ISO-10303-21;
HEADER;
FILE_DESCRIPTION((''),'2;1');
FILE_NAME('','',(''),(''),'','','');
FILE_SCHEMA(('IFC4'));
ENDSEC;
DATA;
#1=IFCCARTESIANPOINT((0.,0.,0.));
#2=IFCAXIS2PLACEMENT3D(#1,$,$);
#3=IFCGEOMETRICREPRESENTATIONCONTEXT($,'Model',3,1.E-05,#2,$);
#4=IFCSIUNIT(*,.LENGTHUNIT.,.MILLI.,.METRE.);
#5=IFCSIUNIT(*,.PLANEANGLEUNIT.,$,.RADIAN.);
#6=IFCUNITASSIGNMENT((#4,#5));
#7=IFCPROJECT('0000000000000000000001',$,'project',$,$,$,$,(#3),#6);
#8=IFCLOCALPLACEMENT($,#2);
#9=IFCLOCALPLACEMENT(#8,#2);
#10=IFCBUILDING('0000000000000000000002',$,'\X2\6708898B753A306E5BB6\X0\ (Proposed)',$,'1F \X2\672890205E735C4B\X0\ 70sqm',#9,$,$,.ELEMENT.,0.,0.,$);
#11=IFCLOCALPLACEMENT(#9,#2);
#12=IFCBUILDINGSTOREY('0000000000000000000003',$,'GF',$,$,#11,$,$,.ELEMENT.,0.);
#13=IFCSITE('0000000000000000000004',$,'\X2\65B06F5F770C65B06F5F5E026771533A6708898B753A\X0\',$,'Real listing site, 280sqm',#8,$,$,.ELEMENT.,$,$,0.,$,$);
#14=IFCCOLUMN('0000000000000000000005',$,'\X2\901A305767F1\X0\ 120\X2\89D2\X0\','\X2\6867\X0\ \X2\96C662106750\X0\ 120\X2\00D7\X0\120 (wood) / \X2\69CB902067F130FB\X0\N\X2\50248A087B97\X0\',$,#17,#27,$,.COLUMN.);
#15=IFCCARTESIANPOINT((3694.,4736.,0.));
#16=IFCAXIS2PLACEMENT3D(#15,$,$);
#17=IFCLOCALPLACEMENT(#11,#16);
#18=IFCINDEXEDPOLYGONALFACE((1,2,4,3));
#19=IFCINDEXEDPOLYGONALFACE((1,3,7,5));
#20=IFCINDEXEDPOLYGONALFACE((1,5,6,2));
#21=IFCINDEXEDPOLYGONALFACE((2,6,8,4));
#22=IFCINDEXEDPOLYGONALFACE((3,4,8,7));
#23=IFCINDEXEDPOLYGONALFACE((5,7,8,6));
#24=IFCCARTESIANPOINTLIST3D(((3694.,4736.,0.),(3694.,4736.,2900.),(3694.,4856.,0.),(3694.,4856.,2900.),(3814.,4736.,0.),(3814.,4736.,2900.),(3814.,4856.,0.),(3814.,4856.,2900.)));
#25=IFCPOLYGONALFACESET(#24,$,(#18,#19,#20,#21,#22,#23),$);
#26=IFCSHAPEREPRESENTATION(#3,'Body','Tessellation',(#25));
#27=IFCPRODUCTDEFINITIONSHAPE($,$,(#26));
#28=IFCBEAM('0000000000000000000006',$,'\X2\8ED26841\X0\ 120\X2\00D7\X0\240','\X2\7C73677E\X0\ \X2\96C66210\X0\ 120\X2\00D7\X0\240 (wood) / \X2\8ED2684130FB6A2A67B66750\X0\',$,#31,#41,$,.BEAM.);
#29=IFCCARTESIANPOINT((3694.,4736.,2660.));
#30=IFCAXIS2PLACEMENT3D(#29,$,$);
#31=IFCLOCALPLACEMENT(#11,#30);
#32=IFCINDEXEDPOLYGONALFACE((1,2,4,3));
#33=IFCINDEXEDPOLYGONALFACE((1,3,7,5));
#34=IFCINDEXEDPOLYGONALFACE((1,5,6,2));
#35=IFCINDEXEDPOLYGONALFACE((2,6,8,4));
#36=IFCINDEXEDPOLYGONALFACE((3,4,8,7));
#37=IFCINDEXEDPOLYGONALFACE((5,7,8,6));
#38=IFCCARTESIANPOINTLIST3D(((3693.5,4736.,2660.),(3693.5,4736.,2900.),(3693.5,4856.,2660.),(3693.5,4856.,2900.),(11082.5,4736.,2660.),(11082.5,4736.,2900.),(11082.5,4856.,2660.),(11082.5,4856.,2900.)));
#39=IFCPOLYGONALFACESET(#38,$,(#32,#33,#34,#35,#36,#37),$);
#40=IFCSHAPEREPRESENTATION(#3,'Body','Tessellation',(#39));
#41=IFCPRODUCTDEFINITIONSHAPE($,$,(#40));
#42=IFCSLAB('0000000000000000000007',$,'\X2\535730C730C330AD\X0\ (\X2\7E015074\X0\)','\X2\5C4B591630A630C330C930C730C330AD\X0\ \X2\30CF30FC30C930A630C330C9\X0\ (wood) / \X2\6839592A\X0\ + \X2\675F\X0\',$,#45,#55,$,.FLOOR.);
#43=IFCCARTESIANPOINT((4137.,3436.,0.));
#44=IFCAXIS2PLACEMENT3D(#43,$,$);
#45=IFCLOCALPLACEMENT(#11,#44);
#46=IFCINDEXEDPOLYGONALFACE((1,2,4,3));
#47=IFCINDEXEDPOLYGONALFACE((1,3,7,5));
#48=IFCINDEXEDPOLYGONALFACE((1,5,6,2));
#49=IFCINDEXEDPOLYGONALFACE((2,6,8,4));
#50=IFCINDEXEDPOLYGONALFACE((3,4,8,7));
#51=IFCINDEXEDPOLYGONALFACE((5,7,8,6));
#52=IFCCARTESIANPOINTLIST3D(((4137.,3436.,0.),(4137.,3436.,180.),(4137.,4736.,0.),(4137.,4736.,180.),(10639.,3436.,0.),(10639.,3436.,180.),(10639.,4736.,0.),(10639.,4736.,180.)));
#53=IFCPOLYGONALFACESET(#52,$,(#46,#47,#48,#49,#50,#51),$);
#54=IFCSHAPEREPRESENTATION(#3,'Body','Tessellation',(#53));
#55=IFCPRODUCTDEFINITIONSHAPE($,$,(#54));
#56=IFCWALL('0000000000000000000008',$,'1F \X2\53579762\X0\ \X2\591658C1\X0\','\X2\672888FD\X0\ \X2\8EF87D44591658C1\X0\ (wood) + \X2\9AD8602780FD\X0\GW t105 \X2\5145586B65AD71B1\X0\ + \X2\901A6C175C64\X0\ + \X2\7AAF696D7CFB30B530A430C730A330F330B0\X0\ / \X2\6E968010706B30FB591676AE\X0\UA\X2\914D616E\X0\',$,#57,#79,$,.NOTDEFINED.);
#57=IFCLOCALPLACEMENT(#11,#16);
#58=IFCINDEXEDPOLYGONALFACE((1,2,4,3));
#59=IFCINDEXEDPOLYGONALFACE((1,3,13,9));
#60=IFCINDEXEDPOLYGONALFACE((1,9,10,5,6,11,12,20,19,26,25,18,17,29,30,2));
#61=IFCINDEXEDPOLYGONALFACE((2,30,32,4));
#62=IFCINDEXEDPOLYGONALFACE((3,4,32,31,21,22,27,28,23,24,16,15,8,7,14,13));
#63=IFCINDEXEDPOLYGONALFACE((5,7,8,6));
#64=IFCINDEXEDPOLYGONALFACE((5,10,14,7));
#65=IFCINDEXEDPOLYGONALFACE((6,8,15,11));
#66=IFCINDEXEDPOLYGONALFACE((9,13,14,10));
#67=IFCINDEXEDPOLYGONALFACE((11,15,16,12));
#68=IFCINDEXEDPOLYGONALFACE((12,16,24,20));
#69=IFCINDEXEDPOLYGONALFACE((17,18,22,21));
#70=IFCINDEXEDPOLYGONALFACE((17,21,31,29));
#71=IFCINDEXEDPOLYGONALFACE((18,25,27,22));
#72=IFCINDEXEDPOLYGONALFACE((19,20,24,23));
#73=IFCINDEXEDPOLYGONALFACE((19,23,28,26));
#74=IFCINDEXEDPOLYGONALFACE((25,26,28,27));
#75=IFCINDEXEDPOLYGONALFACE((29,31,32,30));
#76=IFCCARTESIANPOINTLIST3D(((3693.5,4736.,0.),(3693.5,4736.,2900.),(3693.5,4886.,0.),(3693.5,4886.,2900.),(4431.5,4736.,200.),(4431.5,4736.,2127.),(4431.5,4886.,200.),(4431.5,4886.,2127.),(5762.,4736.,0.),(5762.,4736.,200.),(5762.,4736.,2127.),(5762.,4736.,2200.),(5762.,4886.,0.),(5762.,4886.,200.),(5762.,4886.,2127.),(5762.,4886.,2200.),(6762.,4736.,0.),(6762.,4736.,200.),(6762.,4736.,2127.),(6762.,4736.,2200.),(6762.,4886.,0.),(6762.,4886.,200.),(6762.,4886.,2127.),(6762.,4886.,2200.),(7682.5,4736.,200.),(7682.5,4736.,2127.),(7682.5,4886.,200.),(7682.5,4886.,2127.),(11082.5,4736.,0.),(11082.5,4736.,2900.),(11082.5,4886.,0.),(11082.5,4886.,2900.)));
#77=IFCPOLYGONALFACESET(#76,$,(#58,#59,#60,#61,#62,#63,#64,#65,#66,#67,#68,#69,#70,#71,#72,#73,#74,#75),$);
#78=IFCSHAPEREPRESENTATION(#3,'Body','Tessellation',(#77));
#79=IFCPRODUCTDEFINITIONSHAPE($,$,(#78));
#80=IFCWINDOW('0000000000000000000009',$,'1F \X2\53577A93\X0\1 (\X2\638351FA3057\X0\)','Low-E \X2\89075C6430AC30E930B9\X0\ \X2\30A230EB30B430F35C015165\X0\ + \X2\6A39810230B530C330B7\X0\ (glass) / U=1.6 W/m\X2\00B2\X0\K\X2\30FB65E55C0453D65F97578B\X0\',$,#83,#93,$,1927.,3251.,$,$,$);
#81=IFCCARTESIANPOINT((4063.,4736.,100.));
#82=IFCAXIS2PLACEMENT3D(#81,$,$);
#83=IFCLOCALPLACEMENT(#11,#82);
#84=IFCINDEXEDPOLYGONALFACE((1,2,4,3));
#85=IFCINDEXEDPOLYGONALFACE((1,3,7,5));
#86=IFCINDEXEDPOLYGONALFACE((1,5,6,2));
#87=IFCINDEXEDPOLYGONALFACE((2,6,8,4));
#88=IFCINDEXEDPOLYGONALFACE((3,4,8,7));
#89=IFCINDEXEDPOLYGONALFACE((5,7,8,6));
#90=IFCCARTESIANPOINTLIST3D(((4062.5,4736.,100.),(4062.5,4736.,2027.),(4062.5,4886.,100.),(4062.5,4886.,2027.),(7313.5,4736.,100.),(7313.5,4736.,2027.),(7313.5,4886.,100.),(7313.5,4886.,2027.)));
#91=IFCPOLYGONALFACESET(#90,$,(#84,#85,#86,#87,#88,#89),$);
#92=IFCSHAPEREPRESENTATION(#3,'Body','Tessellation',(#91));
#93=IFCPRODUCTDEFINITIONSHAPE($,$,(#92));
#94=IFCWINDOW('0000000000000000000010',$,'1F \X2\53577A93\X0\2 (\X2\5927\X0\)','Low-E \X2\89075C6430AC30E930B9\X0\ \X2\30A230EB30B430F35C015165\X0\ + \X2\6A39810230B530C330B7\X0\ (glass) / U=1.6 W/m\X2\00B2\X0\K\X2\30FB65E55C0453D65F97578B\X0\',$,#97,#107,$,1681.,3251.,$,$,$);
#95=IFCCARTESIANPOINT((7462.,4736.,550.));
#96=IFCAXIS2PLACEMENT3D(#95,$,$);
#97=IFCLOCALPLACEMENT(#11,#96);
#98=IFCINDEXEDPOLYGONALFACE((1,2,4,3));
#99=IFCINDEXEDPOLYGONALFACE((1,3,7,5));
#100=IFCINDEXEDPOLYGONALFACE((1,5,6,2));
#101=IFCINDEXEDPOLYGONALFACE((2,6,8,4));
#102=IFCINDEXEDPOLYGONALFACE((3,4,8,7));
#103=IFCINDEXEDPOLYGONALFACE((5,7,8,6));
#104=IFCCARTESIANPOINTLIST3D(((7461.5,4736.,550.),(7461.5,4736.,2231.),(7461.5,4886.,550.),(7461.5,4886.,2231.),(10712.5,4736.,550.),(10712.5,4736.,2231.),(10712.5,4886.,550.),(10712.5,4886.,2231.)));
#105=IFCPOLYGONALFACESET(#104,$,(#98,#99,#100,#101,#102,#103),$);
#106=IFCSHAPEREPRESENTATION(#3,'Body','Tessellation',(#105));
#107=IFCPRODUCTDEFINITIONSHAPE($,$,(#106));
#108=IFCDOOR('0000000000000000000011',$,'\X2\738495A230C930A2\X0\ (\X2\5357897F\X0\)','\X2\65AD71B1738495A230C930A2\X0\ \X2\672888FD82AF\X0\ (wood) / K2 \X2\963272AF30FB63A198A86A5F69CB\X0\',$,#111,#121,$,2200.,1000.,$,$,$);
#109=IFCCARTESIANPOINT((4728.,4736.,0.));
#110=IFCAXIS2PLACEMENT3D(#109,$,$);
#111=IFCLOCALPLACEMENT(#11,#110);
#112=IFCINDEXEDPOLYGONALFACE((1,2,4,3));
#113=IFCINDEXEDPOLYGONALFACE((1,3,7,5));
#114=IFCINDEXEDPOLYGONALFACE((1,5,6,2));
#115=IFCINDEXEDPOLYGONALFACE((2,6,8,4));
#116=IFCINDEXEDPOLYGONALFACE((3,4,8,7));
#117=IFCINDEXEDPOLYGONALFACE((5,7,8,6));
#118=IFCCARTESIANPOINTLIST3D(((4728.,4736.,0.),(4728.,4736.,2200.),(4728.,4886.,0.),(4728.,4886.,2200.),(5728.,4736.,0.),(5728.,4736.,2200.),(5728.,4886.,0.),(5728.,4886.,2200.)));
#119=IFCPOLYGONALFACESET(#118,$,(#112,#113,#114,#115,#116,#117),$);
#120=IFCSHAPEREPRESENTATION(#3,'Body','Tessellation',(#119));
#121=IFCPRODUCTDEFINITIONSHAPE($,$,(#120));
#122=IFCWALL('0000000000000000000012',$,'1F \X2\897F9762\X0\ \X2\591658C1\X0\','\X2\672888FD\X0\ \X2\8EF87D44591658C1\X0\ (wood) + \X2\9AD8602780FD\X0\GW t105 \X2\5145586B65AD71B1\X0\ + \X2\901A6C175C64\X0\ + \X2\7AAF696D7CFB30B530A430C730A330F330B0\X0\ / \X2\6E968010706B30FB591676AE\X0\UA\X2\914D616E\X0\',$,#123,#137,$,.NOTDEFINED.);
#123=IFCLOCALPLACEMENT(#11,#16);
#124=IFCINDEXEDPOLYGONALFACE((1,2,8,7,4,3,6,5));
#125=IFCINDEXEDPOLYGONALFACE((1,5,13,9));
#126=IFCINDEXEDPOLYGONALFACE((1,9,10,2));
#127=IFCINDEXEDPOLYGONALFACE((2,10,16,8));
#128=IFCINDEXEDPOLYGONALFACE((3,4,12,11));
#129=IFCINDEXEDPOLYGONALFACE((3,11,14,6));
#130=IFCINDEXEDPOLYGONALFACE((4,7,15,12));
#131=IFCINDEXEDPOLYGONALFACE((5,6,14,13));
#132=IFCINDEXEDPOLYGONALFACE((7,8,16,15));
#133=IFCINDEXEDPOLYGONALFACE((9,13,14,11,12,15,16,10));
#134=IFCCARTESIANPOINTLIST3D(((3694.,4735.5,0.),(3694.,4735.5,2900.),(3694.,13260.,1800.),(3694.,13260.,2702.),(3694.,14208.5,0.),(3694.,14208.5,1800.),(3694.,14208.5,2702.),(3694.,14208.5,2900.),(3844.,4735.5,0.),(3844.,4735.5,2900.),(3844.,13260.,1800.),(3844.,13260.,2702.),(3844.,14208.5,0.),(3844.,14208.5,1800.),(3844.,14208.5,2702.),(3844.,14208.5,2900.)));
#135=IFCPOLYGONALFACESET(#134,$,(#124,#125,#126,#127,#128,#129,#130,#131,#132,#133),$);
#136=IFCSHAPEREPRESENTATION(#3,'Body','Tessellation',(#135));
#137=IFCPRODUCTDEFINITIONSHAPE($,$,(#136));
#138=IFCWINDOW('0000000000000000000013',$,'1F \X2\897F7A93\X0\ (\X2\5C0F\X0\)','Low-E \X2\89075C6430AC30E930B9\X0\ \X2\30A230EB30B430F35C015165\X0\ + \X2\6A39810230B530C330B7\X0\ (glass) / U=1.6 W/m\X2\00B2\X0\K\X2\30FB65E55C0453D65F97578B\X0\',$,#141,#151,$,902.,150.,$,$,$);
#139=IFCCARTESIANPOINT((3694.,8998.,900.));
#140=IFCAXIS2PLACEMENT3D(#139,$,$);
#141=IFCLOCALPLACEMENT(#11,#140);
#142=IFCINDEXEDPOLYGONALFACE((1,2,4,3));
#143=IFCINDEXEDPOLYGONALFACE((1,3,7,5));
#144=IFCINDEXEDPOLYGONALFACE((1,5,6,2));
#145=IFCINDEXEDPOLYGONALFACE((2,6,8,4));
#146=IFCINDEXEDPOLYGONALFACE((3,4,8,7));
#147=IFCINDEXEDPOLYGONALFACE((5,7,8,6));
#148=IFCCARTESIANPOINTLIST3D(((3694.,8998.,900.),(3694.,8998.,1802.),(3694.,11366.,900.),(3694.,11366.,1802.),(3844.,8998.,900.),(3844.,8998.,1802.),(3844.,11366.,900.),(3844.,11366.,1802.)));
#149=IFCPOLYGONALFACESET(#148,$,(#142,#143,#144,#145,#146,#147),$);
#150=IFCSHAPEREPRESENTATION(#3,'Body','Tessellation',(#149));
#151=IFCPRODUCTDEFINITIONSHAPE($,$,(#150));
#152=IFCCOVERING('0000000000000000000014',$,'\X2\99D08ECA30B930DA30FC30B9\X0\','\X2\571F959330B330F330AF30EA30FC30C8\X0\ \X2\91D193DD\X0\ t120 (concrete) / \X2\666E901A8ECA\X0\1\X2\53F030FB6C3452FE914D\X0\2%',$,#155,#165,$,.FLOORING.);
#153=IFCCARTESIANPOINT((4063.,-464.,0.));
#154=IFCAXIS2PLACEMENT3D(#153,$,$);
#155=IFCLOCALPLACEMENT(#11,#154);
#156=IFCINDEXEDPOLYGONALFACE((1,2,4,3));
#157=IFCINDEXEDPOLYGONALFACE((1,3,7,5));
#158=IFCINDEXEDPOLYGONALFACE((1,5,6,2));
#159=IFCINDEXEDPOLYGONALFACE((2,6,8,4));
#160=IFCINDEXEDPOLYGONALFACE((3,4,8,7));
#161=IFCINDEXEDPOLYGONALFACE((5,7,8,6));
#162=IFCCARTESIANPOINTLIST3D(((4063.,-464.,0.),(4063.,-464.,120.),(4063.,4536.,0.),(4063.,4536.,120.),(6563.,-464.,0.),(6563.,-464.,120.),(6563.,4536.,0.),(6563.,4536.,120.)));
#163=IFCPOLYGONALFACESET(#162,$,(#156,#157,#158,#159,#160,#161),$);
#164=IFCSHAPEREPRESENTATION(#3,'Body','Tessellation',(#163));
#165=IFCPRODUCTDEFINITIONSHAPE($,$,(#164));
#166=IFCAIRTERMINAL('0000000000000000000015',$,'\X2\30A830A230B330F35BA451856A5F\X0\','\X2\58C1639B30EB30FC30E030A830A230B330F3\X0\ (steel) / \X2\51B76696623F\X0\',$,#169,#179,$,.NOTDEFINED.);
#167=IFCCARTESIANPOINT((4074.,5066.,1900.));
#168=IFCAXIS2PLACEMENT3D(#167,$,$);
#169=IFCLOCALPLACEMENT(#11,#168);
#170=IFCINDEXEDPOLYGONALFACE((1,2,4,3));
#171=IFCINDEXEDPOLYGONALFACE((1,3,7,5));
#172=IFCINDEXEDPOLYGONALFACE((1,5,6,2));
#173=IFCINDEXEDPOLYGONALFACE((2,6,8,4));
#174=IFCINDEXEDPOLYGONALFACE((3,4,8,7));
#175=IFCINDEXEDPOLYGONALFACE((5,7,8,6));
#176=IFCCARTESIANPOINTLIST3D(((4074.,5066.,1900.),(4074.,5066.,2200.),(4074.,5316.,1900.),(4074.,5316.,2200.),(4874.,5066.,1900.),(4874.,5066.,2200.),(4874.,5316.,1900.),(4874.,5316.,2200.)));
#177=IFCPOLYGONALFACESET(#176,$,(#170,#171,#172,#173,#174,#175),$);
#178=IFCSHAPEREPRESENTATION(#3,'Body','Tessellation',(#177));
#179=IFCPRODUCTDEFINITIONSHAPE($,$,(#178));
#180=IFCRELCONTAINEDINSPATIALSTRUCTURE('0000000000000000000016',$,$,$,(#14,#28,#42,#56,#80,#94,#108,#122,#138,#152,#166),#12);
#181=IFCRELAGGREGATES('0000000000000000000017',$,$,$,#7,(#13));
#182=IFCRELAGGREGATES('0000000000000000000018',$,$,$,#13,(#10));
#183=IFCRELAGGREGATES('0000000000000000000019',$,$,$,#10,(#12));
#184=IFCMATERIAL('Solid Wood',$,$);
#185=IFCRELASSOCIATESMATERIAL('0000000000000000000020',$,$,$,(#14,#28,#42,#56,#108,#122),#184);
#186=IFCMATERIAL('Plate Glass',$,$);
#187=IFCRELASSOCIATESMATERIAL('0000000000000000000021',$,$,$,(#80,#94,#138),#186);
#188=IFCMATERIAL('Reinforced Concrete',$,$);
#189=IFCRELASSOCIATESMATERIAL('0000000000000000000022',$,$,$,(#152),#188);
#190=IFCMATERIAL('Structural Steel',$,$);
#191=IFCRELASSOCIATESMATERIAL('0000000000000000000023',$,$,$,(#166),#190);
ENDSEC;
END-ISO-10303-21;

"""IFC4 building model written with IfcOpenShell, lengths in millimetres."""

from ifc_helpers import new_model, si_unit, frame, frame_2d, origin, place, context, project, spatial, rectangle, extrude, material, element, fill, save


model = new_model("IFC4")

# Units and contexts
model_context = context("Model", 3, precision=1e-05, world=origin())
ifc_project = project(units=[si_unit("LENGTHUNIT", "METRE", prefix="MILLI"), si_unit("PLANEANGLEUNIT", "RADIAN")], contexts=[model_context])

# Site, building, storey
site_placement = place(None, origin())
site = spatial("IfcSite", under=ifc_project, at=site_placement, Name="新潟県新潟市東区月見町", ObjectType="Real listing site, 280sqm", CompositionType="ELEMENT", RefElevation=0.0)
building_placement = place(site_placement, origin())
building = spatial("IfcBuilding", under=site, at=building_placement, Name="月見町の家 (Proposed)", ObjectType="1F 木造平屋 70sqm", CompositionType="ELEMENT", ElevationOfRefHeight=0.0, ElevationOfTerrain=0.0)
storey_placement = place(building_placement, origin())
storey = spatial("IfcBuildingStorey", under=building, at=storey_placement, Name="GF", CompositionType="ELEMENT", Elevation=0.0)

# Column
ifc_material_1 = material(Name="Solid Wood")
column_1_placement = place(storey_placement, frame((3694.0, 4736.0, 0.0)))
element("IfcColumn", 1, at=column_1_placement, inside=storey, material=ifc_material_1, Name="通し柱 120角", Description="桧 集成材 120×120 (wood) / 構造柱・N値計算", PredefinedType="COLUMN", context=model_context, shape_type="SweptSolid", body=[
    extrude(rectangle(XDim=120.0, YDim=120.0, at=frame_2d((60.0, 60.0))), frame((3694.0, 4736.0, 0.0)), (0.0, 0.0, 1.0), 2900.0),
])

# Beam
beam_1_placement = place(storey_placement, frame((3694.0, 4736.0, 2660.0)))
element("IfcBeam", 2, at=beam_1_placement, inside=storey, material=ifc_material_1, Name="軒桁 120×240", Description="米松 集成 120×240 (wood) / 軒桁・横架材", PredefinedType="BEAM", context=model_context, shape_type="SweptSolid", body=[
    extrude(rectangle(XDim=7389.0, YDim=120.0, at=frame_2d((3694.0, 60.0))), frame((3694.0, 4736.0, 2660.0)), (0.0, 0.0, 1.0), 240.0),
])

# Slab
ifc_material_2 = material(Name="Reinforced Concrete")
slab_1_placement = place(storey_placement, frame((4137.0, 3436.0, 0.0)))
element("IfcSlab", 3, at=slab_1_placement, inside=storey, material=ifc_material_1, Name="南デッキ (縁側)", Description="屋外ウッドデッキ ハードウッド (wood) / 根太 + 束", PredefinedType="FLOOR", context=model_context, shape_type="SweptSolid", body=[
    extrude(rectangle(XDim=6502.0, YDim=1300.0, at=frame_2d((3251.0, 650.0))), frame((4137.0, 3436.0, 0.0)), (0.0, 0.0, 1.0), 180.0),
])

# Wall, openings, windows, door
wall_1_placement = place(storey_placement, frame((3694.0, 4736.0, 0.0)))
wall_1 = element("IfcWall", 4, at=wall_1_placement, inside=storey, material=ifc_material_1, Name="1F 南面 外壁", Description="木製 軸組外壁 (wood) + 高性能GW t105 充填断熱 + 通気層 + 窯業系サイディング / 準耐火・外皮UA配慮", PredefinedType="NOTDEFINED", context=model_context, shape_type="SweptSolid", body=[
    extrude(rectangle(XDim=7389.0, YDim=150.0, at=frame_2d((3694.0, 75.0))), frame((3694.0, 4736.0, 0.0)), (0.0, 0.0, 1.0), 2900.0),
])
opening_1_placement = place(storey_placement, frame((4063.0, 4736.0, 100.0)))
opening_1 = element("IfcOpeningElement", 5, at=opening_1_placement, cuts=wall_1, PredefinedType="NOTDEFINED", context=model_context, shape_type="SweptSolid", body=[
    extrude(rectangle(XDim=3251.0, YDim=150.0, at=frame_2d((1625.0, 75.0))), frame((4063.0, 4736.0, 100.0)), (0.0, 0.0, 1.0), 1927.0),
])
opening_2_placement = place(storey_placement, frame((7462.0, 4736.0, 550.0)))
opening_2 = element("IfcOpeningElement", 6, at=opening_2_placement, cuts=wall_1, PredefinedType="NOTDEFINED", context=model_context, shape_type="SweptSolid", body=[
    extrude(rectangle(XDim=3251.0, YDim=150.0, at=frame_2d((1625.0, 75.0))), frame((7462.0, 4736.0, 550.0)), (0.0, 0.0, 1.0), 1681.0),
])
opening_3_placement = place(storey_placement, frame((4728.0, 4736.0, 0.0)))
opening_3 = element("IfcOpeningElement", 7, at=opening_3_placement, cuts=wall_1, PredefinedType="NOTDEFINED", context=model_context, shape_type="SweptSolid", body=[
    extrude(rectangle(XDim=1000.0, YDim=150.0, at=frame_2d((500.0, 75.0))), frame((4728.0, 4736.0, 0.0)), (0.0, 0.0, 1.0), 2200.0),
])
ifc_material_3 = material(Name="Plate Glass")
window_1_placement = place(storey_placement, frame((4063.0, 4736.0, 100.0)))
window_1 = element("IfcWindow", 8, at=window_1_placement, inside=storey, material=ifc_material_3, Name="1F 南窓1 (掃出し)", Description="Low-E 複層ガラス アルゴン封入 + 樹脂サッシ (glass) / U=1.6 W/m²K・日射取得型", OverallHeight=1927.0, OverallWidth=3251.0, context=model_context, shape_type="SweptSolid", body=[
    extrude(rectangle(XDim=3251.0, YDim=150.0, at=frame_2d((1625.0, 75.0))), frame((4063.0, 4736.0, 100.0)), (0.0, 0.0, 1.0), 1927.0),
])
fill(opening_1, window_1)
window_2_placement = place(storey_placement, frame((7462.0, 4736.0, 550.0)))
window_2 = element("IfcWindow", 9, at=window_2_placement, inside=storey, material=ifc_material_3, Name="1F 南窓2 (大)", Description="Low-E 複層ガラス アルゴン封入 + 樹脂サッシ (glass) / U=1.6 W/m²K・日射取得型", OverallHeight=1681.0, OverallWidth=3251.0, context=model_context, shape_type="SweptSolid", body=[
    extrude(rectangle(XDim=3251.0, YDim=150.0, at=frame_2d((1625.0, 75.0))), frame((7462.0, 4736.0, 550.0)), (0.0, 0.0, 1.0), 1681.0),
])
fill(opening_2, window_2)
door_placement = place(storey_placement, frame((4728.0, 4736.0, 0.0)))
door = element("IfcDoor", 10, at=door_placement, inside=storey, material=ifc_material_1, Name="玄関ドア (南西)", Description="断熱玄関ドア 木製芯 (wood) / K2 防犯・採風機構", OverallHeight=2200.0, OverallWidth=1000.0, context=model_context, shape_type="SweptSolid", body=[
    extrude(rectangle(XDim=1000.0, YDim=150.0, at=frame_2d((500.0, 75.0))), frame((4728.0, 4736.0, 0.0)), (0.0, 0.0, 1.0), 2200.0),
])
fill(opening_3, door)

# Wall, opening, window
wall_2_placement = place(storey_placement, frame((3694.0, 4736.0, 0.0)))
wall_2 = element("IfcWall", 11, at=wall_2_placement, inside=storey, material=ifc_material_1, Name="1F 西面 外壁", Description="木製 軸組外壁 (wood) + 高性能GW t105 充填断熱 + 通気層 + 窯業系サイディング / 準耐火・外皮UA配慮", PredefinedType="NOTDEFINED", context=model_context, shape_type="SweptSolid", body=[
    extrude(rectangle(XDim=150.0, YDim=9473.0, at=frame_2d((75.0, 4736.0))), frame((3694.0, 4736.0, 0.0)), (0.0, 0.0, 1.0), 2900.0),
])
opening_4_placement = place(storey_placement, frame((3694.0, 8998.0, 900.0)))
opening_4 = element("IfcOpeningElement", 12, at=opening_4_placement, cuts=wall_2, PredefinedType="NOTDEFINED", context=model_context, shape_type="SweptSolid", body=[
    extrude(rectangle(XDim=150.0, YDim=2368.0, at=frame_2d((75.0, 1184.0))), frame((3694.0, 8998.0, 900.0)), (0.0, 0.0, 1.0), 902.0),
])
window_3_placement = place(storey_placement, frame((3694.0, 8998.0, 900.0)))
window_3 = element("IfcWindow", 13, at=window_3_placement, inside=storey, material=ifc_material_3, Name="1F 西窓 (小)", Description="Low-E 複層ガラス アルゴン封入 + 樹脂サッシ (glass) / U=1.6 W/m²K・日射取得型", OverallHeight=902.0, OverallWidth=150.0, context=model_context, shape_type="SweptSolid", body=[
    extrude(rectangle(XDim=150.0, YDim=2368.0, at=frame_2d((75.0, 1184.0))), frame((3694.0, 8998.0, 900.0)), (0.0, 0.0, 1.0), 902.0),
])
fill(opening_4, window_3)

# Shared definitions
ifc_material_4 = material(Name="Structural Steel")

# Covering
covering_1_placement = place(storey_placement, frame((4063.0, -464.0, 0.0)))
element("IfcCovering", 14, at=covering_1_placement, inside=storey, material=ifc_material_2, Name="駐車スペース", Description="土間コンクリート 金鏝 t120 (concrete) / 普通車1台・水勾配2%", PredefinedType="FLOORING", context=model_context, shape_type="SweptSolid", body=[
    extrude(rectangle(XDim=2500.0, YDim=5000.0, at=frame_2d((1250.0, 2500.0))), frame((4063.0, -464.0, 0.0)), (0.0, 0.0, 1.0), 120.0),
])

# Air terminal
air_terminal_placement = place(storey_placement, frame((4074.0, 5066.0, 1900.0)))
element("IfcAirTerminal", 15, at=air_terminal_placement, inside=storey, material=ifc_material_4, Name="エアコン室内機", Description="壁掛ルームエアコン (steel) / 冷暖房", PredefinedType="NOTDEFINED", context=model_context, shape_type="SweptSolid", body=[
    extrude(rectangle(XDim=800.0, YDim=250.0, at=frame_2d((400.0, 125.0))), frame((4074.0, 5066.0, 1900.0)), (0.0, 0.0, 1.0), 300.0),
])

save(model, "model.ifc")
